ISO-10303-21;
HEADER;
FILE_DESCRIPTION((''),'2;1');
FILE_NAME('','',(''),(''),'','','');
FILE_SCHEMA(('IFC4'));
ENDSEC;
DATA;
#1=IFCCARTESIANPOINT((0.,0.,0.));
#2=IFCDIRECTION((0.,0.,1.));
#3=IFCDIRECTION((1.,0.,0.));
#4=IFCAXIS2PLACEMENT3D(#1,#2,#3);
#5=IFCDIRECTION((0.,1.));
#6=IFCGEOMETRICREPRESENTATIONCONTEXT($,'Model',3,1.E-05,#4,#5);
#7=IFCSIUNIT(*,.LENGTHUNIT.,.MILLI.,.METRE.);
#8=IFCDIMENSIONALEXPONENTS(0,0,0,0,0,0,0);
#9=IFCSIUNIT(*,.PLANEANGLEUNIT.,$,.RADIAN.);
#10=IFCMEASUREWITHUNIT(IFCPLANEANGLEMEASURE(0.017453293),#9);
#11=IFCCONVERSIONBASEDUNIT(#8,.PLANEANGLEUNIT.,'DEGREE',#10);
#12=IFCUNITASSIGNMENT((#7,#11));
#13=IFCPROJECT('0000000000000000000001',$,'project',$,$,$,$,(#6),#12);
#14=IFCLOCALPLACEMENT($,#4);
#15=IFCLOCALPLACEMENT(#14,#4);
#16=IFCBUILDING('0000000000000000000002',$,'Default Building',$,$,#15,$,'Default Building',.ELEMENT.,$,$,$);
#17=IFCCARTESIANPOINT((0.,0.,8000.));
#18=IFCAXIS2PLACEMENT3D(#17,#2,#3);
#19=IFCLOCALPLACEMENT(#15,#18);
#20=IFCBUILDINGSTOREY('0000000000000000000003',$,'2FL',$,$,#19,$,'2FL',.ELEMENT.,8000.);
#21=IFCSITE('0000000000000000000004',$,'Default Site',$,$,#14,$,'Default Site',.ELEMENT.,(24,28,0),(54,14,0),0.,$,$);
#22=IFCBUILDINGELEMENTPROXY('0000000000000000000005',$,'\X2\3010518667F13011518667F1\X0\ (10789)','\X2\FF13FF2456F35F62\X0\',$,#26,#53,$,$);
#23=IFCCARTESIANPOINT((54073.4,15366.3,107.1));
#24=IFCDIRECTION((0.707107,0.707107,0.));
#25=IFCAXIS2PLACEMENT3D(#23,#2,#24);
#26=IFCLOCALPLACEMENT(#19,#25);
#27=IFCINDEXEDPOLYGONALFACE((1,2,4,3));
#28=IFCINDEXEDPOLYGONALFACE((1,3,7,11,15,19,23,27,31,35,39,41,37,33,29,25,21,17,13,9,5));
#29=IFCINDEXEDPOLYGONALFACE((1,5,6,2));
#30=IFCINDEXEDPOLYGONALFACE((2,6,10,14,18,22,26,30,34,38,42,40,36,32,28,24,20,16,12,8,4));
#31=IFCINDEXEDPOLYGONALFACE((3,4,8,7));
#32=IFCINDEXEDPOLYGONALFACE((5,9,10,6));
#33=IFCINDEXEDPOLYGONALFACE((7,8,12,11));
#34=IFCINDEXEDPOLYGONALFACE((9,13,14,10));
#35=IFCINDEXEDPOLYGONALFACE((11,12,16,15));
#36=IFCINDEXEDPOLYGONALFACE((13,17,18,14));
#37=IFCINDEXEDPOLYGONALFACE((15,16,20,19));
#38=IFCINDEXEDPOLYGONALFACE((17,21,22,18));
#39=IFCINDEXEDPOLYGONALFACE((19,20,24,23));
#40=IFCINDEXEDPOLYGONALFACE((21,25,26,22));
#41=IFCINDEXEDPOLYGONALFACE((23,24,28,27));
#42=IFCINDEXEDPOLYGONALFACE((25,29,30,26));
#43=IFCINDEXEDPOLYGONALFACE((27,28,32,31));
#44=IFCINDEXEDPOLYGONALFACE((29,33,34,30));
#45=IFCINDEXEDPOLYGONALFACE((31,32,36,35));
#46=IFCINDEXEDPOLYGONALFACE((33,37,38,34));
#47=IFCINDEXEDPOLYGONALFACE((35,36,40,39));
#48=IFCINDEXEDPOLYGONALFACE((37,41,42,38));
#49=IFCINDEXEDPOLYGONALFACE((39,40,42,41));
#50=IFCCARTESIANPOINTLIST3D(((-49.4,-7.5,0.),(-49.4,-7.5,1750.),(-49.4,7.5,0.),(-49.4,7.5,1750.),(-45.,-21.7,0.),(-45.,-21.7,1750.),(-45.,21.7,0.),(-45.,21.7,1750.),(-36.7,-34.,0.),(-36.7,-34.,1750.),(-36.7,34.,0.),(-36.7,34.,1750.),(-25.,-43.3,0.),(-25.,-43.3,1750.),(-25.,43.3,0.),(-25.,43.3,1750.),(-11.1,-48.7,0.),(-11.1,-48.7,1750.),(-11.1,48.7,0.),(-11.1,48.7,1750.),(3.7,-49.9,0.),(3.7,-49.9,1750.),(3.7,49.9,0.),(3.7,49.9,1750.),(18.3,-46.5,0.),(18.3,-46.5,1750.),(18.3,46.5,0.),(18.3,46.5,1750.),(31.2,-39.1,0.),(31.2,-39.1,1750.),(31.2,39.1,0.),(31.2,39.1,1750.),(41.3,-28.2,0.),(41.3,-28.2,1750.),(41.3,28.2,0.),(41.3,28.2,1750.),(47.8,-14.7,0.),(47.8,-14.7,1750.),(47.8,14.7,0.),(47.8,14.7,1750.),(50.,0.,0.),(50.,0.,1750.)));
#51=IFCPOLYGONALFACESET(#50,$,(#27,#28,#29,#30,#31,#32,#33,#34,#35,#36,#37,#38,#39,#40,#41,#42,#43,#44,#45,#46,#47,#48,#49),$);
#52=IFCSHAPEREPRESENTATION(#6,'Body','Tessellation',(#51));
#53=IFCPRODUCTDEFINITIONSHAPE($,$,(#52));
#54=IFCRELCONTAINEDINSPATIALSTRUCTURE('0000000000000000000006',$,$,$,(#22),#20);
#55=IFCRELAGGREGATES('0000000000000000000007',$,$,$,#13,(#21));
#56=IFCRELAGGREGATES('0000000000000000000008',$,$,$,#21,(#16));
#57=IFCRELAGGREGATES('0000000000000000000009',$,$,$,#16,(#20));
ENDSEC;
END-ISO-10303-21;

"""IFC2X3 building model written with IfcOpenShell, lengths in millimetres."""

from ifc_helpers import new_model, entity, si_unit, converted_unit, direction, frame, origin_with_axes, origin_2d_with_axis, place, context, project, spatial, circle, extrude, source, transform, mapped, element, save


model = new_model("IFC2X3")

# Units and contexts
model_context = context("Model", 3, precision=1e-05, world=origin_with_axes(), true_north=direction((0.0, 1.0)))
ifc_project = project(units=[si_unit("LENGTHUNIT", "METRE", prefix="MILLI"), converted_unit("PLANEANGLEUNIT", "DEGREE", entity("IfcPlaneAngleMeasure", 0.017453293), si_unit("PLANEANGLEUNIT", "RADIAN"), dimensions=[0, 0, 0, 0, 0, 0, 0])], contexts=[model_context])

# Site, building, storey
site_placement = place(None, origin_with_axes())
site = spatial("IfcSite", under=ifc_project, at=site_placement, Name="Default Site", LongName="Default Site", CompositionType="ELEMENT", RefLatitude=(24, 28, 0), RefLongitude=(54, 14, 0), RefElevation=0.0)
building_placement = place(site_placement, origin_with_axes())
building = spatial("IfcBuilding", under=site, at=building_placement, Name="Default Building", LongName="Default Building", CompositionType="ELEMENT")
storey_placement = place(building_placement, frame((0.0, 0.0, 8000.0), z_axis=(0.0, 0.0, 1.0), x_axis=(1.0, 0.0, 0.0)))
storey = spatial("IfcBuildingStorey", under=building, at=storey_placement, Name="2FL", LongName="2FL", CompositionType="ELEMENT", Elevation=8000.0)

# Building element proxy
shared_shape_1 = source(origin_with_axes(), model_context, "Body", "SweptSolid", [
    extrude(circle(Radius=50.0, at=origin_2d_with_axis()), frame((0.0, 0.0, 0.0), z_axis=(0.0, 0.0, 1.0), x_axis=(1.0, 0.0, 0.0)), (0.0, 0.0, 1.0), 1750.0),
])
proxy_1_placement = place(storey_placement, frame((54073.4, 15366.3, 107.1), z_axis=(0.0, 0.0, 1.0), x_axis=(0.707107, 0.707107, 0.0)))
element("IfcBuildingElementProxy", 1, at=proxy_1_placement, inside=storey, Name="【円柱】円柱 (10789)", Description="３Ｄ図形", context=model_context, shape_type="MappedRepresentation", body=[
    mapped(shared_shape_1, transform((0.0, 0.0, 0.0))),
])

save(model, "model.ifc")
